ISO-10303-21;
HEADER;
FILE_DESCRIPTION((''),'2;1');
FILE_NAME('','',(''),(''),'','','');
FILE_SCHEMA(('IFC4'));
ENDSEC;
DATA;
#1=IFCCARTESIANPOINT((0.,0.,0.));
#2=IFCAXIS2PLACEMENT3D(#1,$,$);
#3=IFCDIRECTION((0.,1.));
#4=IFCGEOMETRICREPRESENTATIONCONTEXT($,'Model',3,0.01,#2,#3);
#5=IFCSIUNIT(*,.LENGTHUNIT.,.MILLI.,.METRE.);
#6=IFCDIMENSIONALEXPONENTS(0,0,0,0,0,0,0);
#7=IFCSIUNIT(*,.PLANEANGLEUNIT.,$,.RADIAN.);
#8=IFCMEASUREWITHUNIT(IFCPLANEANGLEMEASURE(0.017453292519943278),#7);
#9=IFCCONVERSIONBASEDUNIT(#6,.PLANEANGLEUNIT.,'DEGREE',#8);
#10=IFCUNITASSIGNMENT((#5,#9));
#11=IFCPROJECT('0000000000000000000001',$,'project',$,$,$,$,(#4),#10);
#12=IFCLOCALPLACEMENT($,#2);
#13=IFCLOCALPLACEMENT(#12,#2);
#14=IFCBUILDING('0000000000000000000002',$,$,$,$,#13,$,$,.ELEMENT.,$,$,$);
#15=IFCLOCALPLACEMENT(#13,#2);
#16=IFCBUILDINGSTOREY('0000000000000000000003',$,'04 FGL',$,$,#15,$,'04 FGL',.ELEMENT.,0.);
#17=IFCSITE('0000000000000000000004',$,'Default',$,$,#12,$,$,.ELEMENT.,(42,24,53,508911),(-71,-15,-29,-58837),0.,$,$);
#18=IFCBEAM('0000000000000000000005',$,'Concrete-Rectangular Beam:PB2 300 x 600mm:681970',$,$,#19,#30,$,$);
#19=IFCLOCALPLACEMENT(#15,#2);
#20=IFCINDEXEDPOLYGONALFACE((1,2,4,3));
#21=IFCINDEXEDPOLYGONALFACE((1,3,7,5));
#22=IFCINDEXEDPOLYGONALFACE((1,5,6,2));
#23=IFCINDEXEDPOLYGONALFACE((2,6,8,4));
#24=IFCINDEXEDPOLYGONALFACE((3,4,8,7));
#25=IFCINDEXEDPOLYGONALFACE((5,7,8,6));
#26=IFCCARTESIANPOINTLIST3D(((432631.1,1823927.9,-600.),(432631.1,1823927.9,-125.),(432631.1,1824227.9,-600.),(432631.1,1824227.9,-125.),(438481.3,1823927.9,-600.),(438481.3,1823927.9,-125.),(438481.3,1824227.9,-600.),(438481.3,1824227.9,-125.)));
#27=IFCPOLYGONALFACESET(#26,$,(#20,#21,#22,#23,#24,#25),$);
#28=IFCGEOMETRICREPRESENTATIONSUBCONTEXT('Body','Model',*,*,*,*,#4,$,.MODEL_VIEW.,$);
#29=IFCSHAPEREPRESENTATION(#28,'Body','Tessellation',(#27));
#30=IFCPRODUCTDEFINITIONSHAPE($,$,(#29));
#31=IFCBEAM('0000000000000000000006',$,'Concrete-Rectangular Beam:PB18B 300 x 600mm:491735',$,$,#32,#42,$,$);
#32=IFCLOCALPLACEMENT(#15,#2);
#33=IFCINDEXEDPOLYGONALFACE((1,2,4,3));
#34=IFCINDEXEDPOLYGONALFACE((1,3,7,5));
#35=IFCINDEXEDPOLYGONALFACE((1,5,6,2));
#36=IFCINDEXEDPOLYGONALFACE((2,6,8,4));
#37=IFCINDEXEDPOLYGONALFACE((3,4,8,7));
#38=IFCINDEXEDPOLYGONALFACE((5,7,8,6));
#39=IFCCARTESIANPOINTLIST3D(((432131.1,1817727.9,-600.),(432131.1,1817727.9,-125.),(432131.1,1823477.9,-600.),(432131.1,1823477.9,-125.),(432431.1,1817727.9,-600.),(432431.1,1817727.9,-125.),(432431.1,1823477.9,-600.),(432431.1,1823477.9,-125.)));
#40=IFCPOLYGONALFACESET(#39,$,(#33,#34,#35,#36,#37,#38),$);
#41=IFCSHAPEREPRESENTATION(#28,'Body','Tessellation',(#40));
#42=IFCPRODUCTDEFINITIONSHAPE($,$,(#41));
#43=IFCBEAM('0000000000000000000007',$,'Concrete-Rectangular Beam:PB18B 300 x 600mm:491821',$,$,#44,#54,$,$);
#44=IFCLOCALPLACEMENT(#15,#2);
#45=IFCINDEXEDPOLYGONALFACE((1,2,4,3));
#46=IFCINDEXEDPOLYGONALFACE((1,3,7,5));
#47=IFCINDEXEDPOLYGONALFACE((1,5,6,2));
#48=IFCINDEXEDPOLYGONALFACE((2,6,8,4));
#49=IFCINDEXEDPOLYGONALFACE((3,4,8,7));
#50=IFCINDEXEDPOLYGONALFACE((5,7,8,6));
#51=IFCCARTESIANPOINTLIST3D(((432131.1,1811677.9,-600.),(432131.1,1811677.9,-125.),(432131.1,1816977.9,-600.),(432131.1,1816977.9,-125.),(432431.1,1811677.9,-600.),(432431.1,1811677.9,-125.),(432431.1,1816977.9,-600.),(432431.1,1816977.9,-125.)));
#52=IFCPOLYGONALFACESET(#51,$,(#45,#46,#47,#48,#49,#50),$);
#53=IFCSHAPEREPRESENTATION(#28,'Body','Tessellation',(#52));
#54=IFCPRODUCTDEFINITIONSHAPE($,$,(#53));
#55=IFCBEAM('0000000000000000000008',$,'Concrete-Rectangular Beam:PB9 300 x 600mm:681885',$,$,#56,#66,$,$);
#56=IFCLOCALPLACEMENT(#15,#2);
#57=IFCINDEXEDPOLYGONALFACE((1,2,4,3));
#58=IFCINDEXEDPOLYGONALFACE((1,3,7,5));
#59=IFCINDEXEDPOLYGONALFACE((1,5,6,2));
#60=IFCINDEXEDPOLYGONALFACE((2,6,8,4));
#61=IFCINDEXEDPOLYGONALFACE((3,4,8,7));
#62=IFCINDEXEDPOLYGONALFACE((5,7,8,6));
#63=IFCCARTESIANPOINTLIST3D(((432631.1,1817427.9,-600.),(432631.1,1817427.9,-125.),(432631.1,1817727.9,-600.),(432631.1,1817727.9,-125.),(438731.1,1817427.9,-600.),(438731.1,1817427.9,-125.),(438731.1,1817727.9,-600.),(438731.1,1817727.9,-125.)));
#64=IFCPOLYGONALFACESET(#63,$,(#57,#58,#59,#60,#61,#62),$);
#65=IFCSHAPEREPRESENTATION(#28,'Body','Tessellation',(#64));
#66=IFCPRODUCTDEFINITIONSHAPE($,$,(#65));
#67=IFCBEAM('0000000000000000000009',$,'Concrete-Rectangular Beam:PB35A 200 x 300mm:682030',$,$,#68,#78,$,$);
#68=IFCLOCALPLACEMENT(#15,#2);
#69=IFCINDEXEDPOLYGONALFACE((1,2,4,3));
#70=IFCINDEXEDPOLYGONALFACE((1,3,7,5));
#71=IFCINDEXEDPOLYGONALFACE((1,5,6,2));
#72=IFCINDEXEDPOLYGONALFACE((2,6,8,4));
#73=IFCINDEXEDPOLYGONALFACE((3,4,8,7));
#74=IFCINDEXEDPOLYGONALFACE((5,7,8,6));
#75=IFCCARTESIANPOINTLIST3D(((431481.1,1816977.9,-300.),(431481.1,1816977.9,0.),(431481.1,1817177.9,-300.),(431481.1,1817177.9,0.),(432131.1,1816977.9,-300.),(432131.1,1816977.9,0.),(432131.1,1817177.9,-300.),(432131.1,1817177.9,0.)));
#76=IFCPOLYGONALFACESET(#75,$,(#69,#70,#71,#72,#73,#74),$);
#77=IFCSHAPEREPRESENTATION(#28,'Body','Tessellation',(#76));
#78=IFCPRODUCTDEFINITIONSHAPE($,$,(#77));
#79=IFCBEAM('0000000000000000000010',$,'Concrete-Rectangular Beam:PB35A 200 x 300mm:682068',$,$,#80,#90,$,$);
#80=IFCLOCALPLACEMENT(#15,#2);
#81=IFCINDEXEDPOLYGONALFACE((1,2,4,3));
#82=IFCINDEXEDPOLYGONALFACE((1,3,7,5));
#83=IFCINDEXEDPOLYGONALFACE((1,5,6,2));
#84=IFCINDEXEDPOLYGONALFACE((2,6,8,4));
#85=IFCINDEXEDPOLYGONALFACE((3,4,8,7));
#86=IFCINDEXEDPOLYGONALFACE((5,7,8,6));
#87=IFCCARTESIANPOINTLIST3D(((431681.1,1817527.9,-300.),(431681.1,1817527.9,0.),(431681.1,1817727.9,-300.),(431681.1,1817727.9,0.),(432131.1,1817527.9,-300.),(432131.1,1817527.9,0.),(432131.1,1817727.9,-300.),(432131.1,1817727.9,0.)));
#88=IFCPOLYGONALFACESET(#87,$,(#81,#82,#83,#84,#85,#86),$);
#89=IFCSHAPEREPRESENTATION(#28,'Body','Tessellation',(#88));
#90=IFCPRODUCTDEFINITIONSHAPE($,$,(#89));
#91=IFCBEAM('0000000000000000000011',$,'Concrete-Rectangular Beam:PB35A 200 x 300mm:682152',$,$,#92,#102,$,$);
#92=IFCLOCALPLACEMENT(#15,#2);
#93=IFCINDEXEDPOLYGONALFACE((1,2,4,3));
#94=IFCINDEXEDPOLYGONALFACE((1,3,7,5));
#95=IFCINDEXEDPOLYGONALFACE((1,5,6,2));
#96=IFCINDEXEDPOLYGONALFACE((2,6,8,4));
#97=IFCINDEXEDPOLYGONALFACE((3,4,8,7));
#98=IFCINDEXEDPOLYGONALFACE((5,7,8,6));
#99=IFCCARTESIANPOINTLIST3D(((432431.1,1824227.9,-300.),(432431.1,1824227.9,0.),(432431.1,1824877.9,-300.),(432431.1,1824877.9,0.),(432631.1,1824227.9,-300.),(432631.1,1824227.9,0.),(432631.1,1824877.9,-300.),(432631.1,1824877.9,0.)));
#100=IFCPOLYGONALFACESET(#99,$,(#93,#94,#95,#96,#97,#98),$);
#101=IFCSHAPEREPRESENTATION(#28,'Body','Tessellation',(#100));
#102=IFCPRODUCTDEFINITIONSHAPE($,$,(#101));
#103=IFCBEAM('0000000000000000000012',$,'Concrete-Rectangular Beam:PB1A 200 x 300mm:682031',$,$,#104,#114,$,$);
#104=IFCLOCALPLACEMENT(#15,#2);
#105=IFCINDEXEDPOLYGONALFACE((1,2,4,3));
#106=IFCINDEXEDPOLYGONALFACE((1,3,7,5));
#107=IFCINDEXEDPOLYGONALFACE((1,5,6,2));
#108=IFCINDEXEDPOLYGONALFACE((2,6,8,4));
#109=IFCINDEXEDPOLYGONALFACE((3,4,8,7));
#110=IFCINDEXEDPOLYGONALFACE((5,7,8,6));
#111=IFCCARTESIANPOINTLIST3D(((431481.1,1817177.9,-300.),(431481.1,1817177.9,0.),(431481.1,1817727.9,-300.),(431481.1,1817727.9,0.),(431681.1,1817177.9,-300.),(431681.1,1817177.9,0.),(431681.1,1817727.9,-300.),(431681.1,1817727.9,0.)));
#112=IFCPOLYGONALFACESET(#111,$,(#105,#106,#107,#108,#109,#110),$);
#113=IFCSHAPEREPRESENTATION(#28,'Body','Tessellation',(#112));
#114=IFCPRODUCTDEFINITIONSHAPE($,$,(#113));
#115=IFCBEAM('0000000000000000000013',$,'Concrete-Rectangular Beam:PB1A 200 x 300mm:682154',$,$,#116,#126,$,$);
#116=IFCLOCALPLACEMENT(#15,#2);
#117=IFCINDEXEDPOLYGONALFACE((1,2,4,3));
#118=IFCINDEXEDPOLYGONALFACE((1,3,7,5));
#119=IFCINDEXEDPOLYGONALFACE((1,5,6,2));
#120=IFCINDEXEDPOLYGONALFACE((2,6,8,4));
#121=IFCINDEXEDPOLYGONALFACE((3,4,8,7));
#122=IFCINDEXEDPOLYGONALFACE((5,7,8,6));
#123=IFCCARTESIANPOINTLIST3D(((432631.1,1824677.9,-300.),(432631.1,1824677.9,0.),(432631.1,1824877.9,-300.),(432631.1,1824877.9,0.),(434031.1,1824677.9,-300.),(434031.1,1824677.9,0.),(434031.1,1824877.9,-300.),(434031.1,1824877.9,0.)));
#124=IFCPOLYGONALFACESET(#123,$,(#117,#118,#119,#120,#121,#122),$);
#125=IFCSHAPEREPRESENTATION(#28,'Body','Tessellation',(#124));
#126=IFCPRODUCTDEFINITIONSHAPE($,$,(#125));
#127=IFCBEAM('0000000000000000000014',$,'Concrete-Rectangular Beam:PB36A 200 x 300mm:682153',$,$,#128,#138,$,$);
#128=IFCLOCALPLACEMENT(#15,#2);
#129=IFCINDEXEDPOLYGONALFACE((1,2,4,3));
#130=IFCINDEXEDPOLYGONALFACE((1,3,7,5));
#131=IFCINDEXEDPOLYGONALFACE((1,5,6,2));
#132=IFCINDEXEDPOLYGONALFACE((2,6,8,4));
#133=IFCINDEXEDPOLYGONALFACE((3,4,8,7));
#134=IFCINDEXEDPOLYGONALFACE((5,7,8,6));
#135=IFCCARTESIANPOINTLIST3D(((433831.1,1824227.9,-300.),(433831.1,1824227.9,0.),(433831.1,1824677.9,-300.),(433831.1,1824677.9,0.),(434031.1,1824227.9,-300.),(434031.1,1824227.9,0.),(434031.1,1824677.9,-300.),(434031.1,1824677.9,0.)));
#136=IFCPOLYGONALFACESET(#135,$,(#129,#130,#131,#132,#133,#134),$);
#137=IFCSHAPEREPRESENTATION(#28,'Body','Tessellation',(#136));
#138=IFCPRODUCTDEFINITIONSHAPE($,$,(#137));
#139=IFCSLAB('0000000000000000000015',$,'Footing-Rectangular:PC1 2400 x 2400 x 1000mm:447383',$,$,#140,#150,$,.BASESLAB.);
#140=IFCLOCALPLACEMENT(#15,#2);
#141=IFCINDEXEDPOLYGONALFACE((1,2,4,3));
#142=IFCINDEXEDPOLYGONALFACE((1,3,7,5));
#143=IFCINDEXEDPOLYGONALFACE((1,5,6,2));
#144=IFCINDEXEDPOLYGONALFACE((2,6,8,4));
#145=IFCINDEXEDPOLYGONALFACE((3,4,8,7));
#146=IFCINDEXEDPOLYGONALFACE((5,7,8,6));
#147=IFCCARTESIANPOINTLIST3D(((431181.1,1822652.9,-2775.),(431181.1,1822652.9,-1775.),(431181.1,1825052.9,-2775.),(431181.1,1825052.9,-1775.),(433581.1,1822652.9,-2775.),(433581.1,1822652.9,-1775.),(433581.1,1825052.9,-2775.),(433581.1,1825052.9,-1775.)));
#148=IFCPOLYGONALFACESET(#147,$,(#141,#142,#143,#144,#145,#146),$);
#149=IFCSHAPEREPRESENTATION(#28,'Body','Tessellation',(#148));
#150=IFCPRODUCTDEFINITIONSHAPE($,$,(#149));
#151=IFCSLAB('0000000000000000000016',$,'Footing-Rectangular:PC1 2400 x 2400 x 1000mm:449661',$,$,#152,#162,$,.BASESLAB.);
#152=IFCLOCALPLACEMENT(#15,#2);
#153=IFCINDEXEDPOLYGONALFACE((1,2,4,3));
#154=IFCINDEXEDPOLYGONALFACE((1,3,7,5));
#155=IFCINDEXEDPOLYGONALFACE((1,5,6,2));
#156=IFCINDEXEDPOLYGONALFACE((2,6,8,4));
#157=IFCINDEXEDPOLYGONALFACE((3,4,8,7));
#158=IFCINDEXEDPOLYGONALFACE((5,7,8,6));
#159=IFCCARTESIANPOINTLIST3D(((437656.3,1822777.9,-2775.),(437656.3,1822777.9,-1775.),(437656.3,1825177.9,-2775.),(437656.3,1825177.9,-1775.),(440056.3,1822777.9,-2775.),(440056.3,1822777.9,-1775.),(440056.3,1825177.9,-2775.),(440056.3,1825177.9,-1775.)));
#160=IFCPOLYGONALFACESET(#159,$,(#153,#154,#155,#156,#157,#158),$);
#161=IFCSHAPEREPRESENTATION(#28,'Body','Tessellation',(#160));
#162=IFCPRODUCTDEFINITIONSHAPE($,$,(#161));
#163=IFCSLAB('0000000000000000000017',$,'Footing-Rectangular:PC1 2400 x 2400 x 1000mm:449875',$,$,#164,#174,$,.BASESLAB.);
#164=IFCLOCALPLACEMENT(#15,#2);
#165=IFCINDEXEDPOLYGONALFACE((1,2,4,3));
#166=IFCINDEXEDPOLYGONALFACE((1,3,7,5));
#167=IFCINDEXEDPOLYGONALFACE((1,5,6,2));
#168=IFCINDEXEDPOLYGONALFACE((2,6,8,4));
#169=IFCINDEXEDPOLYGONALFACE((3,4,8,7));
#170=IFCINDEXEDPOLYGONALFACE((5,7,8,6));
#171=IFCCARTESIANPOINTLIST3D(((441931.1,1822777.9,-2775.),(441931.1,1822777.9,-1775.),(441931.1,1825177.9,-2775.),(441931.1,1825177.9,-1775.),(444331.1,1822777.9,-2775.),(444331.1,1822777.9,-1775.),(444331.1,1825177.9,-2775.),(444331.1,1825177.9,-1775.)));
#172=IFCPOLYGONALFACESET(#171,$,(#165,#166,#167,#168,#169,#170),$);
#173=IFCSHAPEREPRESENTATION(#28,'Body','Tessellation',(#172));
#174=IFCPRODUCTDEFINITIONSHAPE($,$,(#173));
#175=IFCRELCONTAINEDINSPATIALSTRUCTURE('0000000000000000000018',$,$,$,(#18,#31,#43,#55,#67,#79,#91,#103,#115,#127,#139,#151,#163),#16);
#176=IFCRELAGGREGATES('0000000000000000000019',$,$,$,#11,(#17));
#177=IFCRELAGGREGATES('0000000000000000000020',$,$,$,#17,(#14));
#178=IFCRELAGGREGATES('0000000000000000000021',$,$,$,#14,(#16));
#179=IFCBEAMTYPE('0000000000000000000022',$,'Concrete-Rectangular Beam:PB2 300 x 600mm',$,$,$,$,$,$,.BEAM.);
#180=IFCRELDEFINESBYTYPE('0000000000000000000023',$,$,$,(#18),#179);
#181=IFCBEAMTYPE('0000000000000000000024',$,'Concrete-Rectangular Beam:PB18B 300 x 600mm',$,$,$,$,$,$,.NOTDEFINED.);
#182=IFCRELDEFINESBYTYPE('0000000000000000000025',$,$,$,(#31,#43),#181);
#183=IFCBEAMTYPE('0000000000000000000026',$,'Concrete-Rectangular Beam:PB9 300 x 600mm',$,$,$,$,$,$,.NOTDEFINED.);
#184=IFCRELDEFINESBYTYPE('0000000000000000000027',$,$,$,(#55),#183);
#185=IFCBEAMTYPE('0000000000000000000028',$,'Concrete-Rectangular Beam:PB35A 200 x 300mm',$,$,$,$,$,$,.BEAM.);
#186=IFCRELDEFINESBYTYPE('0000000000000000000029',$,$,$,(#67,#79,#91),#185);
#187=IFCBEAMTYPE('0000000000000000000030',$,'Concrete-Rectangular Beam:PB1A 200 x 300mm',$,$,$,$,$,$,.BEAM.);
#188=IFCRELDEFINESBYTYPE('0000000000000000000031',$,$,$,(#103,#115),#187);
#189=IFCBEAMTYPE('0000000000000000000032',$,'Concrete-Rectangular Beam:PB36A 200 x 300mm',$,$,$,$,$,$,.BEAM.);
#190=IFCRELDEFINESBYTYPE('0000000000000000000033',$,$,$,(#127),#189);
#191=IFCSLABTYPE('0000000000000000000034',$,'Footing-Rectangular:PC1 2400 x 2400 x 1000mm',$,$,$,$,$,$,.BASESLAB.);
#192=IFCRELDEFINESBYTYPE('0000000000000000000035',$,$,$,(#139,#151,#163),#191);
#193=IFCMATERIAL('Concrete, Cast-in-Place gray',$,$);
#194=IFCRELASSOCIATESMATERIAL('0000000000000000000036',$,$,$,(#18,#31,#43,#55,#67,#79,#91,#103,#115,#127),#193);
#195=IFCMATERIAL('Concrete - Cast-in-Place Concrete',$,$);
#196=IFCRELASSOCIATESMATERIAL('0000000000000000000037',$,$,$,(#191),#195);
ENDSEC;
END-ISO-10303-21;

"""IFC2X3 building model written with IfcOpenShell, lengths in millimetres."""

from ifc_helpers import new_model, entity, si_unit, converted_unit, direction, frame, frame_2d, origin, origin_2d_with_axis, place, context, subcontext, project, spatial, rectangle, extrude, material, type_object, element, save


model = new_model("IFC2X3")

# Units and contexts
model_context = context("Model", 3, precision=0.01, world=origin(), true_north=direction((0.0, 1.0)))
body_context = subcontext(model_context, "Body", "Model", "MODEL_VIEW")
ifc_project = project(units=[si_unit("LENGTHUNIT", "METRE", prefix="MILLI"), converted_unit("PLANEANGLEUNIT", "DEGREE", entity("IfcPlaneAngleMeasure", 0.017453292519943278), si_unit("PLANEANGLEUNIT", "RADIAN"), dimensions=[0, 0, 0, 0, 0, 0, 0])], contexts=[model_context])

# Site, building, storey
site_placement = place(None, origin())
site = spatial("IfcSite", under=ifc_project, at=site_placement, Name="Default", CompositionType="ELEMENT", RefLatitude=(42, 24, 53, 508911), RefLongitude=(-71, -15, -29, -58837), RefElevation=0.0)
building_placement = place(site_placement, origin())
building = spatial("IfcBuilding", under=site, at=building_placement, CompositionType="ELEMENT")
storey_placement = place(building_placement, origin())
storey = spatial("IfcBuildingStorey", under=building, at=storey_placement, Name="04 FGL", LongName="04 FGL", CompositionType="ELEMENT", Elevation=0.0)

# Beams
ifc_material_1 = material(Name="Concrete, Cast-in-Place gray")
beam_type_1 = type_object("IfcBeamType", Name="Concrete-Rectangular Beam:PB2 300 x 600mm", PredefinedType="BEAM")
beam_1_placement = place(storey_placement, frame((432631.1, 1824077.9, 0.0)))
element("IfcBeam", 1, at=beam_1_placement, inside=storey, type_object=beam_type_1, material=ifc_material_1, Name="Concrete-Rectangular Beam:PB2 300 x 600mm:681970", context=body_context, shape_type="SweptSolid", body=[
    extrude(rectangle(XDim=475.0, YDim=300.0, at=origin_2d_with_axis()), frame((0.0, 0.0, -362.5), z_axis=(1.0, 0.0, 0.0), x_axis=(0.0, 0.0, -1.0)), (0.0, 0.0, 1.0), 5850.2),
])
beam_type_2 = type_object("IfcBeamType", Name="Concrete-Rectangular Beam:PB18B 300 x 600mm", PredefinedType="NOTDEFINED")
beam_2_placement = place(storey_placement, frame((432431.1, 1823477.9, 0.0), z_axis=(0.0, 0.0, 1.0), x_axis=(0.0, -1.0, 0.0)))
element("IfcBeam", 2, at=beam_2_placement, inside=storey, type_object=beam_type_2, material=ifc_material_1, Name="Concrete-Rectangular Beam:PB18B 300 x 600mm:491735", context=body_context, shape_type="SweptSolid", body=[
    extrude(rectangle(XDim=475.0, YDim=300.0, at=origin_2d_with_axis()), frame((0.0, -150.0, -362.5), z_axis=(1.0, 0.0, 0.0), x_axis=(0.0, 0.0, -1.0)), (0.0, 0.0, 1.0), 5750.0),
])
beam_3_placement = place(storey_placement, frame((432431.1, 1816977.9, 0.0), z_axis=(0.0, 0.0, 1.0), x_axis=(0.0, -1.0, 0.0)))
element("IfcBeam", 3, at=beam_3_placement, inside=storey, type_object=beam_type_2, material=ifc_material_1, Name="Concrete-Rectangular Beam:PB18B 300 x 600mm:491821", context=body_context, shape_type="SweptSolid", body=[
    extrude(rectangle(XDim=475.0, YDim=300.0, at=origin_2d_with_axis()), frame((0.0, -150.0, -362.5), z_axis=(1.0, 0.0, 0.0), x_axis=(0.0, 0.0, -1.0)), (0.0, 0.0, 1.0), 5300.0),
])
beam_type_3 = type_object("IfcBeamType", Name="Concrete-Rectangular Beam:PB9 300 x 600mm", PredefinedType="NOTDEFINED")
beam_4_placement = place(storey_placement, frame((432631.1, 1817727.9, 0.0)))
element("IfcBeam", 4, at=beam_4_placement, inside=storey, type_object=beam_type_3, material=ifc_material_1, Name="Concrete-Rectangular Beam:PB9 300 x 600mm:681885", context=body_context, shape_type="SweptSolid", body=[
    extrude(rectangle(XDim=475.0, YDim=300.0, at=origin_2d_with_axis()), frame((0.0, -150.0, -362.5), z_axis=(1.0, 0.0, 0.0), x_axis=(0.0, 0.0, -1.0)), (0.0, 0.0, 1.0), 6100.0),
])
beam_type_4 = type_object("IfcBeamType", Name="Concrete-Rectangular Beam:PB35A 200 x 300mm", PredefinedType="BEAM")
beam_5_placement = place(storey_placement, frame((432131.1, 1816977.9, 0.0), z_axis=(0.0, 0.0, 1.0), x_axis=(-1.0, 0.0, 0.0)))
element("IfcBeam", 5, at=beam_5_placement, inside=storey, type_object=beam_type_4, material=ifc_material_1, Name="Concrete-Rectangular Beam:PB35A 200 x 300mm:682030", context=body_context, shape_type="SweptSolid", body=[
    extrude(rectangle(XDim=300.0, YDim=200.0, at=frame_2d((0.0, 0.0), x_axis=(1.0, 0.0))), frame((0.0, -100.0, -150.0), z_axis=(1.0, 0.0, 0.0), x_axis=(0.0, 0.0, -1.0)), (0.0, 0.0, 1.0), 650.0),
])
beam_6_placement = place(storey_placement, frame((432131.1, 1817527.9, 0.0), z_axis=(0.0, 0.0, 1.0), x_axis=(-1.0, 0.0, 0.0)))
element("IfcBeam", 6, at=beam_6_placement, inside=storey, type_object=beam_type_4, material=ifc_material_1, Name="Concrete-Rectangular Beam:PB35A 200 x 300mm:682068", context=body_context, shape_type="SweptSolid", body=[
    extrude(rectangle(XDim=300.0, YDim=200.0, at=frame_2d((0.0, 0.0), x_axis=(1.0, 0.0))), frame((0.0, -100.0, -150.0), z_axis=(1.0, 0.0, 0.0), x_axis=(0.0, 0.0, -1.0)), (0.0, 0.0, 1.0), 450.0),
])
beam_7_placement = place(storey_placement, frame((432431.1, 1824227.9, 0.0), z_axis=(0.0, 0.0, 1.0), x_axis=(0.0, 1.0, 0.0)))
element("IfcBeam", 7, at=beam_7_placement, inside=storey, type_object=beam_type_4, material=ifc_material_1, Name="Concrete-Rectangular Beam:PB35A 200 x 300mm:682152", context=body_context, shape_type="SweptSolid", body=[
    extrude(rectangle(XDim=300.0, YDim=200.0, at=frame_2d((0.0, 0.0), x_axis=(1.0, 0.0))), frame((0.0, -100.0, -150.0), z_axis=(1.0, 0.0, 0.0), x_axis=(0.0, 0.0, -1.0)), (0.0, 0.0, 1.0), 650.0),
])
beam_type_5 = type_object("IfcBeamType", Name="Concrete-Rectangular Beam:PB1A 200 x 300mm", PredefinedType="BEAM")
beam_8_placement = place(storey_placement, frame((431481.1, 1816977.9, 0.0), z_axis=(0.0, 0.0, 1.0), x_axis=(0.0, 1.0, 0.0)))
element("IfcBeam", 8, at=beam_8_placement, inside=storey, type_object=beam_type_5, material=ifc_material_1, Name="Concrete-Rectangular Beam:PB1A 200 x 300mm:682031", context=body_context, shape_type="SweptSolid", body=[
    extrude(rectangle(XDim=300.0, YDim=200.0, at=frame_2d((0.0, 0.0), x_axis=(1.0, 0.0))), frame((200.0, -100.0, -150.0), z_axis=(1.0, 0.0, 0.0), x_axis=(0.0, 0.0, -1.0)), (0.0, 0.0, 1.0), 550.0),
])
beam_9_placement = place(storey_placement, frame((432431.1, 1824877.9, 0.0)))
element("IfcBeam", 9, at=beam_9_placement, inside=storey, type_object=beam_type_5, material=ifc_material_1, Name="Concrete-Rectangular Beam:PB1A 200 x 300mm:682154", context=body_context, shape_type="SweptSolid", body=[
    extrude(rectangle(XDim=300.0, YDim=200.0, at=frame_2d((0.0, 0.0), x_axis=(1.0, 0.0))), frame((200.0, -100.0, -150.0), z_axis=(1.0, 0.0, 0.0), x_axis=(0.0, 0.0, -1.0)), (0.0, 0.0, 1.0), 1400.0),
])
beam_type_6 = type_object("IfcBeamType", Name="Concrete-Rectangular Beam:PB36A 200 x 300mm", PredefinedType="BEAM")
beam_10_placement = place(storey_placement, frame((433831.1, 1824077.9, 0.0), z_axis=(0.0, 0.0, 1.0), x_axis=(0.0, 1.0, 0.0)))
element("IfcBeam", 10, at=beam_10_placement, inside=storey, type_object=beam_type_6, material=ifc_material_1, Name="Concrete-Rectangular Beam:PB36A 200 x 300mm:682153", context=body_context, shape_type="SweptSolid", body=[
    extrude(rectangle(XDim=300.0, YDim=200.0, at=frame_2d((0.0, 0.0), x_axis=(1.0, 0.0))), frame((150.0, -100.0, -150.0), z_axis=(1.0, 0.0, 0.0), x_axis=(0.0, 0.0, -1.0)), (0.0, 0.0, 1.0), 450.0),
])

# Slabs
ifc_material_2 = material(Name="Concrete - Cast-in-Place Concrete")
slab_type_1 = type_object("IfcSlabType", Name="Footing-Rectangular:PC1 2400 x 2400 x 1000mm", PredefinedType="BASESLAB", material=ifc_material_2)
slab_1_placement = place(storey_placement, origin())
element("IfcSlab", 11, at=slab_1_placement, inside=storey, type_object=slab_type_1, Name="Footing-Rectangular:PC1 2400 x 2400 x 1000mm:447383", PredefinedType="BASESLAB", context=body_context, shape_type="SweptSolid", body=[
    extrude(rectangle(XDim=2400.0, YDim=2400.0, at=origin_2d_with_axis()), frame((432381.1, 1823852.9, -2775.0), z_axis=(0.0, 0.0, 1.0), x_axis=(-1.0, 0.0, 0.0)), (0.0, 0.0, 1.0), 1000.0),
])
slab_2_placement = place(storey_placement, origin())
element("IfcSlab", 12, at=slab_2_placement, inside=storey, type_object=slab_type_1, Name="Footing-Rectangular:PC1 2400 x 2400 x 1000mm:449661", PredefinedType="BASESLAB", context=body_context, shape_type="SweptSolid", body=[
    extrude(rectangle(XDim=2400.0, YDim=2400.0, at=origin_2d_with_axis()), frame((438856.3, 1823977.9, -2775.0), z_axis=(0.0, 0.0, 1.0), x_axis=(-1.0, 0.0, 0.0)), (0.0, 0.0, 1.0), 1000.0),
])
slab_3_placement = place(storey_placement, origin())
element("IfcSlab", 13, at=slab_3_placement, inside=storey, type_object=slab_type_1, Name="Footing-Rectangular:PC1 2400 x 2400 x 1000mm:449875", PredefinedType="BASESLAB", context=body_context, shape_type="SweptSolid", body=[
    extrude(rectangle(XDim=2400.0, YDim=2400.0, at=origin_2d_with_axis()), frame((443131.1, 1823977.9, -2775.0), z_axis=(0.0, 0.0, 1.0), x_axis=(-1.0, 0.0, 0.0)), (0.0, 0.0, 1.0), 1000.0),
])

save(model, "model.ifc")
